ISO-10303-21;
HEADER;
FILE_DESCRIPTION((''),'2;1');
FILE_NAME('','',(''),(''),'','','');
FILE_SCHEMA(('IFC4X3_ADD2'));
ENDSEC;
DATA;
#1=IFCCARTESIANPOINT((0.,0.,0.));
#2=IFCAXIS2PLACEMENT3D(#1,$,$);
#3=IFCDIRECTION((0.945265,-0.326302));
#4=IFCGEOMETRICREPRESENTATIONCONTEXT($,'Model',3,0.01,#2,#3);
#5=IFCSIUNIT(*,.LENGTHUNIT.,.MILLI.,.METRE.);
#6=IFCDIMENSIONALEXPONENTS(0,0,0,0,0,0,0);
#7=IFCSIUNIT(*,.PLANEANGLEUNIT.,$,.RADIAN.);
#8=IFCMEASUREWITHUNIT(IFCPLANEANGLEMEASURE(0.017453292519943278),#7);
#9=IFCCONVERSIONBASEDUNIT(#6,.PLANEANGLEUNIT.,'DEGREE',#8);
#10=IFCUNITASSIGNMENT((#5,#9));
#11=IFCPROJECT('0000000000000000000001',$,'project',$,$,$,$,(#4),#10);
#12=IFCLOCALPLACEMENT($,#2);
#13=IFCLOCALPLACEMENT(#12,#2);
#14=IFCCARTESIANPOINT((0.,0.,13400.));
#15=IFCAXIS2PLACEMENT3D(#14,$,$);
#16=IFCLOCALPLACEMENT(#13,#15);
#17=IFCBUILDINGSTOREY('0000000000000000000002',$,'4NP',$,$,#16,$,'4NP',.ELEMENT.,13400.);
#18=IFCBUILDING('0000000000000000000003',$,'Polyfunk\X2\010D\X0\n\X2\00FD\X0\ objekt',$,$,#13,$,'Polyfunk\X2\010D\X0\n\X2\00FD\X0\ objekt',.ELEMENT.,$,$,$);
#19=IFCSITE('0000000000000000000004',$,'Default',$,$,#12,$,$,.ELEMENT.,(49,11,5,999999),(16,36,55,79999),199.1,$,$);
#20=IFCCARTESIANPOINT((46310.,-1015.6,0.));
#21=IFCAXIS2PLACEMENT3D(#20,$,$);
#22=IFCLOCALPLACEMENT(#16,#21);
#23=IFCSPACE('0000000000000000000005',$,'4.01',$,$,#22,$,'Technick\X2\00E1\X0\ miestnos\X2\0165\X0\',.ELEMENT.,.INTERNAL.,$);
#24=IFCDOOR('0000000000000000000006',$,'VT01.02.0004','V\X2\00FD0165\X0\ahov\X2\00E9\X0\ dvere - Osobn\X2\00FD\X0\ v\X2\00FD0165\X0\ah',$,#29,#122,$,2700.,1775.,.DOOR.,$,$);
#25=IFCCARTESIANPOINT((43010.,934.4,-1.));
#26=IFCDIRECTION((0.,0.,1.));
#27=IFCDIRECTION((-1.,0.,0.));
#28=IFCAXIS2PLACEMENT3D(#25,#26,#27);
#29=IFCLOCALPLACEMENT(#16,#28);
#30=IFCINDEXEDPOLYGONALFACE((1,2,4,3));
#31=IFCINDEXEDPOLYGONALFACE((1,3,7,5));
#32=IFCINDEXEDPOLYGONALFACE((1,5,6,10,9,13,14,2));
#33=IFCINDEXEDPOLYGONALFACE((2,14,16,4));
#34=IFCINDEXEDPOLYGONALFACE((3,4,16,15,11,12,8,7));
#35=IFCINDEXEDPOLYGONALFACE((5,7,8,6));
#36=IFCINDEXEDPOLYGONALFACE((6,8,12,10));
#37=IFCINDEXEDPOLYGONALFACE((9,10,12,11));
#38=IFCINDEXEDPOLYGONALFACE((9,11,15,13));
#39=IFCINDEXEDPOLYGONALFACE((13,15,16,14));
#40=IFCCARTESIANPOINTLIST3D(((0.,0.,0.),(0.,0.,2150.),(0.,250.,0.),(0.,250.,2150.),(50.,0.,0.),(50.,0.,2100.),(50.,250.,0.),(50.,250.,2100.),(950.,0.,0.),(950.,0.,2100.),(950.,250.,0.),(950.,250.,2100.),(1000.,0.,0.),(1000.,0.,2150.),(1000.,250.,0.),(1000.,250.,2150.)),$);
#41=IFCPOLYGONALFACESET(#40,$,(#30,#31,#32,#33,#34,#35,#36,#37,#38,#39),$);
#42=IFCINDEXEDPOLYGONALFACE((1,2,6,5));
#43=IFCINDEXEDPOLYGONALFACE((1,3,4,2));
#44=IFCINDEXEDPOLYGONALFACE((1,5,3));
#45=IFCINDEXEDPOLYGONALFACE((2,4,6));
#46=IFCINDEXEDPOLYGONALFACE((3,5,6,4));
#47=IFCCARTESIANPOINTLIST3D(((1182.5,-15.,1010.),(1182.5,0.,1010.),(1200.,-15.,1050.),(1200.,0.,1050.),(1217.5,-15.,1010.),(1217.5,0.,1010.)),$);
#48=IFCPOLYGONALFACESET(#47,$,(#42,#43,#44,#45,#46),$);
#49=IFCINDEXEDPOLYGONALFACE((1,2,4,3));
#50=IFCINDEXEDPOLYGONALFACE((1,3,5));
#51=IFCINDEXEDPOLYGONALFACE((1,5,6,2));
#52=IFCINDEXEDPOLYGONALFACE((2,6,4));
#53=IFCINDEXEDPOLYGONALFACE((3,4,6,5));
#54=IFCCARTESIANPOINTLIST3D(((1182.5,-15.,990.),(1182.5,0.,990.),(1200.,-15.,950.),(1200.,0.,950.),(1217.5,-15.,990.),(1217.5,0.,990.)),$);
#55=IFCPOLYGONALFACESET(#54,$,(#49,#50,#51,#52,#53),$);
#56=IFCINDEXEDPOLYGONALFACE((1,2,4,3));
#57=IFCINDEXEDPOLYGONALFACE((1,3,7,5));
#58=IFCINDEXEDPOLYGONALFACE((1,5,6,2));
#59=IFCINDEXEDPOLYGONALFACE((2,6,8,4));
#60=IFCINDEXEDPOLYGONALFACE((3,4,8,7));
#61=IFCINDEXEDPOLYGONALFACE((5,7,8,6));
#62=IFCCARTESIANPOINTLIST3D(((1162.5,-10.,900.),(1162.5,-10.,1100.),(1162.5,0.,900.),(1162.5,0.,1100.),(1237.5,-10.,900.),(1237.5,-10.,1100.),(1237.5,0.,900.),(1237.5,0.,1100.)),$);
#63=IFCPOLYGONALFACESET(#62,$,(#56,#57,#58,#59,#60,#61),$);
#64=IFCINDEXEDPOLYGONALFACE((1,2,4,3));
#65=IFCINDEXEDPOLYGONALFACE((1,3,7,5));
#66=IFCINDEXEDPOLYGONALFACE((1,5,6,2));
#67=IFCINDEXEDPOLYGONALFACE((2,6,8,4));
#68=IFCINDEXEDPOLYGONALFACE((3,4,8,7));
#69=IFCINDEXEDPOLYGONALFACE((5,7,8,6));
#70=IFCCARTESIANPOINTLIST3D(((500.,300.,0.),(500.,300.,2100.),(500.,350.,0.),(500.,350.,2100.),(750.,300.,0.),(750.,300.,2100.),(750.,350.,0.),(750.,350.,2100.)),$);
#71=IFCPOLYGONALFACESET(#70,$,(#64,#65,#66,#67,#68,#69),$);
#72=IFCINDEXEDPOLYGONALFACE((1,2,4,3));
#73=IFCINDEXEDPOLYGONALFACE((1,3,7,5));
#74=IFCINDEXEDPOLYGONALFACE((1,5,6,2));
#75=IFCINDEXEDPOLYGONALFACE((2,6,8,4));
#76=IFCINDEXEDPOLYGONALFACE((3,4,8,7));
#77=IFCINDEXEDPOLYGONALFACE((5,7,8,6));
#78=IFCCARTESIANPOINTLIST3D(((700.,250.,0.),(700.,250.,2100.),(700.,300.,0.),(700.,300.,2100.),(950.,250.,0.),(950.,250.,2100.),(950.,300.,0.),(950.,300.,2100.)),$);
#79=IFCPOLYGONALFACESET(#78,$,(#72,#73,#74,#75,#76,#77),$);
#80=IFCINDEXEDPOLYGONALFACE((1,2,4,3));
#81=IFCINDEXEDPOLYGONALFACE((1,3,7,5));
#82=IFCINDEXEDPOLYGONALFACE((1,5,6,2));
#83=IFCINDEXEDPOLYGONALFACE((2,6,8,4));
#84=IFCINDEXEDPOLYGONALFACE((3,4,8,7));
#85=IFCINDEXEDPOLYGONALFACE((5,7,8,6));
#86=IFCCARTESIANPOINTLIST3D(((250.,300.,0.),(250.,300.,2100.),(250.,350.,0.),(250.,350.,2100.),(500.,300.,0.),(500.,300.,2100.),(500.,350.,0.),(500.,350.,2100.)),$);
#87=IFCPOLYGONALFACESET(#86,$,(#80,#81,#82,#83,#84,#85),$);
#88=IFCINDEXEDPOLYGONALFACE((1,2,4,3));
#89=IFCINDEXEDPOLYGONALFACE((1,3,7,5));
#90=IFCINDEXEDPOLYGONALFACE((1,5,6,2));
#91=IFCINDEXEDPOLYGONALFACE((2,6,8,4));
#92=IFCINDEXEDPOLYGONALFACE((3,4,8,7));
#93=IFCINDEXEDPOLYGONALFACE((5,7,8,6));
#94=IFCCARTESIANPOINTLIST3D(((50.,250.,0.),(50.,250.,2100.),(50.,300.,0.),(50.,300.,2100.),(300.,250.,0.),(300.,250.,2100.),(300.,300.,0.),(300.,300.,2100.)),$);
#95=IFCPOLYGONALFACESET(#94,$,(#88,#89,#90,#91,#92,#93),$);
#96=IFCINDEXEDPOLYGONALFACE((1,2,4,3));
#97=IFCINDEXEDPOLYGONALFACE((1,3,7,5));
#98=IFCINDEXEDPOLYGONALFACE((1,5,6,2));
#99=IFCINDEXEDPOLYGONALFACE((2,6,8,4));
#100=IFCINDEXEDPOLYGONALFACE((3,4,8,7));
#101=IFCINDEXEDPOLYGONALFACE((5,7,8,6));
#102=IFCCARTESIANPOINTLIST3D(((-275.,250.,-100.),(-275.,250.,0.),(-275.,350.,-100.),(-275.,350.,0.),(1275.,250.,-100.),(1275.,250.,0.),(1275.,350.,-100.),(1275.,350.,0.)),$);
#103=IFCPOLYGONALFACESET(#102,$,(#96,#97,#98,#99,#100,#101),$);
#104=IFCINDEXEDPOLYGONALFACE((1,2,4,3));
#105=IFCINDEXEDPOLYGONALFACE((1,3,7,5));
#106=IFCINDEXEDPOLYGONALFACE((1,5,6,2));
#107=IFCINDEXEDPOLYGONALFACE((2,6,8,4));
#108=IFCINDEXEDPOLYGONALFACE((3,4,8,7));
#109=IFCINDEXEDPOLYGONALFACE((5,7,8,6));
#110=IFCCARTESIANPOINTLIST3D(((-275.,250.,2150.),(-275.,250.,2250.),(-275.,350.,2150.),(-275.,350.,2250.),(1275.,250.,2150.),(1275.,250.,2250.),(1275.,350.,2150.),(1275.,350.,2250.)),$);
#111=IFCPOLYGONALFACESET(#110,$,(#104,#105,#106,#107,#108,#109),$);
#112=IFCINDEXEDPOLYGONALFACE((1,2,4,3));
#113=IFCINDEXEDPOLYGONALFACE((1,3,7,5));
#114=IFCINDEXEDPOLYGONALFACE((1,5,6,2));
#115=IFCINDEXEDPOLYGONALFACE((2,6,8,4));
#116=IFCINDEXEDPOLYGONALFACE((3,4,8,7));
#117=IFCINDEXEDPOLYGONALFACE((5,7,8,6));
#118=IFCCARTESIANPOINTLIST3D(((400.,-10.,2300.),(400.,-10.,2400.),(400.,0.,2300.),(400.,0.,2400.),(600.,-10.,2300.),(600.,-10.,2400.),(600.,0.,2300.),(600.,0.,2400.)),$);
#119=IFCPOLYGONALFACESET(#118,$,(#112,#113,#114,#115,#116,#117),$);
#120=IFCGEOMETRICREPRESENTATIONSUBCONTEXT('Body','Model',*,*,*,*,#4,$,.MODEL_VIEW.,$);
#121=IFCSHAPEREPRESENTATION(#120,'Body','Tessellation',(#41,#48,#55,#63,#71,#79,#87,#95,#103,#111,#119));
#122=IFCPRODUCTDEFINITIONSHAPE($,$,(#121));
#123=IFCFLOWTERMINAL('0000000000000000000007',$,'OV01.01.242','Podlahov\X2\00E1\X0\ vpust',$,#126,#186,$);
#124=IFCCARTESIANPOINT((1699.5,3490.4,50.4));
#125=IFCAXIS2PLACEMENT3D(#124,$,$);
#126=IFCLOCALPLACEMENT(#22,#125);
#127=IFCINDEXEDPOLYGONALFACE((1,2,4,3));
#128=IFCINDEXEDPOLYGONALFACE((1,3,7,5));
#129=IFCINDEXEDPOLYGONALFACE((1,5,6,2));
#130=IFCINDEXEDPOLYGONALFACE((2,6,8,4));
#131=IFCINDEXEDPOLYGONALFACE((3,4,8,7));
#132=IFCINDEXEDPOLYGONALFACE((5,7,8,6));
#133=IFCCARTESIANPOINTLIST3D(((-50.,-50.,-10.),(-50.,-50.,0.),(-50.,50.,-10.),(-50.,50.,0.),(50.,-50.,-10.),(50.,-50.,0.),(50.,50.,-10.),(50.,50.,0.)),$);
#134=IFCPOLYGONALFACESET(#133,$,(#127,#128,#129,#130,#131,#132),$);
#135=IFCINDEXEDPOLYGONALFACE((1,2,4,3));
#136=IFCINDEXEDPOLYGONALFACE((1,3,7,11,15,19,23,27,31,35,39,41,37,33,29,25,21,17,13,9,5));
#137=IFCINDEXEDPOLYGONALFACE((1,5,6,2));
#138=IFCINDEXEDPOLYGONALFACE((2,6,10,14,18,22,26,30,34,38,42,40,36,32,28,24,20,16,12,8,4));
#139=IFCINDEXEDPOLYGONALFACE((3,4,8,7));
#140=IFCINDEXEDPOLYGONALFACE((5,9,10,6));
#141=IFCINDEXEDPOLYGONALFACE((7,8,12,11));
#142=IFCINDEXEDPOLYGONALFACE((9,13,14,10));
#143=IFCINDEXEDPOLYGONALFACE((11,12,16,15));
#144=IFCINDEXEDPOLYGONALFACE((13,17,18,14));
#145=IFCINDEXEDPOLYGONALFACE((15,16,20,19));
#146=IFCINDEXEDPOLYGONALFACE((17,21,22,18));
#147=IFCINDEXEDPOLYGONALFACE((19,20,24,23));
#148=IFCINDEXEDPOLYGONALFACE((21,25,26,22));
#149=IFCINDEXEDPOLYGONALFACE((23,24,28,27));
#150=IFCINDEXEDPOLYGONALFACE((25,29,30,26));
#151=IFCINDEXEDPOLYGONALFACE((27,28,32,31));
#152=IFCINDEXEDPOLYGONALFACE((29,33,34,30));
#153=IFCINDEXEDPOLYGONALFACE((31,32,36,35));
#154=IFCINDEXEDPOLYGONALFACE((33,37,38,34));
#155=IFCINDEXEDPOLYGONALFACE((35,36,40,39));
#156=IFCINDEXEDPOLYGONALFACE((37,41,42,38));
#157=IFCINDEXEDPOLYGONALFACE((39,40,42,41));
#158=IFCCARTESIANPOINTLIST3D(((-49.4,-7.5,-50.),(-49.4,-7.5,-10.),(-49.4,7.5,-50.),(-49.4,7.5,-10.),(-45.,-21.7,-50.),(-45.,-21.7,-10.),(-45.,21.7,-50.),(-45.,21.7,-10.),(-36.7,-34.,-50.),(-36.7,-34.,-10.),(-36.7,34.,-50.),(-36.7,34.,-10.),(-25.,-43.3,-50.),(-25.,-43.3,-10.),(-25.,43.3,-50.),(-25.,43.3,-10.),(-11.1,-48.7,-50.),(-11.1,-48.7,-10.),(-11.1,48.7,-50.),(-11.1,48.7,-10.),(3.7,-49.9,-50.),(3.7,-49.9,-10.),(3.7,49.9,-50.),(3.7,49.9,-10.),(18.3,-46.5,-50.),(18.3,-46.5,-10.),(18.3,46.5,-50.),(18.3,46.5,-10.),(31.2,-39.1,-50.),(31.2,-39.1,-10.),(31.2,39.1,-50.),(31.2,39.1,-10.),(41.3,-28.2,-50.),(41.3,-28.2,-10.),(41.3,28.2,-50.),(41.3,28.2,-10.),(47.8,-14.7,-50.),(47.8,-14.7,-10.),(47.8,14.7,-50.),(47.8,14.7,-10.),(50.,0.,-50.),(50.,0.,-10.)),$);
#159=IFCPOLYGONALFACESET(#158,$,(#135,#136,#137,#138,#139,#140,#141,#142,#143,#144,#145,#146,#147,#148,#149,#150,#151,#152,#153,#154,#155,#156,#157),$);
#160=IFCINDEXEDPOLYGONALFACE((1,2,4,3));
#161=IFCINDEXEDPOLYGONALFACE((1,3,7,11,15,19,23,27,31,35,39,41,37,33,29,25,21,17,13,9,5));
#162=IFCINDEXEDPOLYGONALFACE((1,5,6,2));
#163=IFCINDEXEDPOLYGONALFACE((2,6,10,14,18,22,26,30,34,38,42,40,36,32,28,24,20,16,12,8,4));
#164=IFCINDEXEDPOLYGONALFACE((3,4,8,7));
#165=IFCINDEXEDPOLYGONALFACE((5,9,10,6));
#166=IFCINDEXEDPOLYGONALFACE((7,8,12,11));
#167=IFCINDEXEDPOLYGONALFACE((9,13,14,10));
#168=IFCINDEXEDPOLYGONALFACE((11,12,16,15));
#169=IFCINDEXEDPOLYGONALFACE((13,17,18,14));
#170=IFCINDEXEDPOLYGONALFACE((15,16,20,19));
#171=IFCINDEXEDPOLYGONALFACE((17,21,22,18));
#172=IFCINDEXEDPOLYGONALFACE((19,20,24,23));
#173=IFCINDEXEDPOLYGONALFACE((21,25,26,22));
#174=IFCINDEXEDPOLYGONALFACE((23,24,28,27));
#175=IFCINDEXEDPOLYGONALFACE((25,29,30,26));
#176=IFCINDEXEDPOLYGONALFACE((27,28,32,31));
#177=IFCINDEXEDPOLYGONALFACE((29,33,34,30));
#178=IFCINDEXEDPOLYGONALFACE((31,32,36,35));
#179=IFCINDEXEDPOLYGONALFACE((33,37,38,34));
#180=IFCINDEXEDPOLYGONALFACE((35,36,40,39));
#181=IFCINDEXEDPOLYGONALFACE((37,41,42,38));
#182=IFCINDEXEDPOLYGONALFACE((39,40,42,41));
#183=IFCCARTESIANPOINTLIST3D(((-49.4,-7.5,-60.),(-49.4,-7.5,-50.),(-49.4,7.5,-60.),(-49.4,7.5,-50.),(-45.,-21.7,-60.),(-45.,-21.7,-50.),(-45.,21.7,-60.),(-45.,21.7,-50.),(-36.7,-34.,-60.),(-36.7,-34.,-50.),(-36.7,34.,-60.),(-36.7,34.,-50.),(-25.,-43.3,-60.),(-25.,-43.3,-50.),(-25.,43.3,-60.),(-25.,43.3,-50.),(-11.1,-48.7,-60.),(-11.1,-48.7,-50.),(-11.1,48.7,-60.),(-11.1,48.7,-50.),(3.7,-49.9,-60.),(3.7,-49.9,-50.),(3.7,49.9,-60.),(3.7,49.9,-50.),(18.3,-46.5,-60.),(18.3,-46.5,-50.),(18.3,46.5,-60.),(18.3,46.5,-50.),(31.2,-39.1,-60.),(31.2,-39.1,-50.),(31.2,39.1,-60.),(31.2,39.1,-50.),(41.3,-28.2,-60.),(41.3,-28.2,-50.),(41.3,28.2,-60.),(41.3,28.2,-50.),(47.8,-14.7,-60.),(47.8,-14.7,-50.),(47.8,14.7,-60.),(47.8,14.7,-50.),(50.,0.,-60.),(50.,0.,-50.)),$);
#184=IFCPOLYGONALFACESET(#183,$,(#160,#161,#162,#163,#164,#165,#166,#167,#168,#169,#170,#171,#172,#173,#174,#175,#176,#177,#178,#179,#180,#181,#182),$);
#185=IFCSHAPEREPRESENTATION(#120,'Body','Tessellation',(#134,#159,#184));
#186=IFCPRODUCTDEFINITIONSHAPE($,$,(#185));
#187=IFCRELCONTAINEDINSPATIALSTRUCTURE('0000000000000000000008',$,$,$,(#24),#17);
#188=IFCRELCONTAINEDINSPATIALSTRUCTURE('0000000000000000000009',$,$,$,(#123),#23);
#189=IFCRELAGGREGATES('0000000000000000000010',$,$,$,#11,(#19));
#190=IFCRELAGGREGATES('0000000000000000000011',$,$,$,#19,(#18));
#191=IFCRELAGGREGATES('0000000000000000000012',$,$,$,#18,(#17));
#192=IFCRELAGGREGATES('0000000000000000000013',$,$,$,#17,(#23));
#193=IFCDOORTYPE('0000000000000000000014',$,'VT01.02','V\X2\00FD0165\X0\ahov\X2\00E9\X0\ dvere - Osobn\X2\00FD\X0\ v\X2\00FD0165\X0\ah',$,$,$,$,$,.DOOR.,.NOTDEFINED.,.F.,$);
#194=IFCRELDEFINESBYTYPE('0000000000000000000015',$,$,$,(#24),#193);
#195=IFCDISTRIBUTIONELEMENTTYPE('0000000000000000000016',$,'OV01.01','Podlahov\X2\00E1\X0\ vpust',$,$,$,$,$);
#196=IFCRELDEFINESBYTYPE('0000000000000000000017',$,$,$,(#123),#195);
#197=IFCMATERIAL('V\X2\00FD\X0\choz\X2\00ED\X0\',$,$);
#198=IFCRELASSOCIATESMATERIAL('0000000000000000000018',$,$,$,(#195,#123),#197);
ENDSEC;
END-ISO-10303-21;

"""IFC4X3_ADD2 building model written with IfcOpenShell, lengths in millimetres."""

from ifc_helpers import new_model, entity, si_unit, converted_unit, direction, frame, frame_2d, origin, origin_2d_with_axis, place, context, subcontext, project, spatial, polyline, rectangle, circle, outline, extrude, source, transform, mapped, material, type_object, type_shapes, element, save


model = new_model("IFC4X3_ADD2")

# Units and contexts
model_context = context("Model", 3, precision=0.01, world=origin(), true_north=direction((0.945265, -0.326302)))
body_context = subcontext(model_context, "Body", "Model", "MODEL_VIEW")
ifc_project = project(units=[si_unit("LENGTHUNIT", "METRE", prefix="MILLI"), converted_unit("PLANEANGLEUNIT", "DEGREE", entity("IfcPlaneAngleMeasure", 0.017453292519943278), si_unit("PLANEANGLEUNIT", "RADIAN"), dimensions=[0, 0, 0, 0, 0, 0, 0])], contexts=[model_context])

# Site, building, storey
site_placement = place(None, origin())
site = spatial("IfcSite", under=ifc_project, at=site_placement, Name="Default", CompositionType="ELEMENT", RefLatitude=(49, 11, 5, 999999), RefLongitude=(16, 36, 55, 79999), RefElevation=199.1)
building_placement = place(site_placement, origin())
building = spatial("IfcBuilding", under=site, at=building_placement, Name="Polyfunkčný objekt", LongName="Polyfunkčný objekt", CompositionType="ELEMENT")
storey_placement = place(building_placement, frame((0.0, 0.0, 13400.0)))
storey = spatial("IfcBuildingStorey", under=building, at=storey_placement, Name="4NP", LongName="4NP", CompositionType="ELEMENT", Elevation=13400.0)

# Door
door_type_1 = type_object("IfcDoorType", Name="VT01.02", Description="Výťahové dvere - Osobný výťah", OperationType="NOTDEFINED", ParameterTakesPrecedence=False, PredefinedType="DOOR")
shared_shape_1 = source(origin(), body_context, "Body", "SweptSolid", [
    extrude(outline(polyline([(-1087.5, -500.0), (1062.5, -500.0), (1062.5, -450.0), (-1037.5, -450.0), (-1037.5, 450.0), (1062.5, 450.0), (1062.5, 500.0), (-1087.5, 500.0), (-1087.5, -500.0)])), frame((500.0, 0.0, 1062.5), z_axis=(0.0, 1.0, 0.0), x_axis=(0.0, 0.0, -1.0)), (0.0, 0.0, 1.0), 250.0),
    extrude(outline(polyline([(-24.4, -10.7), (19.2, -10.7), (5.2, 21.4), (-24.4, -10.7)])), frame((1200.0, -15.0, 1023.3), z_axis=(0.0, 1.0, 0.0), x_axis=(0.400819, 0.0, -0.916157)), (0.0, 0.0, 1.0), 15.0),
    extrude(outline(polyline([(-24.4, -10.7), (19.2, -10.7), (5.2, 21.4), (-24.4, -10.7)])), frame((1200.0, -15.0, 976.7), z_axis=(0.0, 1.0, 0.0), x_axis=(-0.400819, 0.0, 0.916157)), (0.0, 0.0, 1.0), 15.0),
    extrude(rectangle(XDim=10.0, YDim=75.0, at=frame_2d((0.0, 0.0), x_axis=(1.0, 0.0))), frame((1200.0, -5.0, 900.0), z_axis=(0.0, 0.0, 1.0), x_axis=(0.0, 1.0, 0.0)), (0.0, 0.0, 1.0), 200.0),
    extrude(rectangle(XDim=50.0, YDim=250.0, at=origin_2d_with_axis()), frame((625.0, 325.0, 0.0), z_axis=(0.0, 0.0, 1.0), x_axis=(0.0, -1.0, 0.0)), (0.0, 0.0, 1.0), 2100.0),
    extrude(rectangle(XDim=50.0, YDim=250.0, at=frame_2d((0.0, 0.0), x_axis=(1.0, 0.0))), frame((825.0, 275.0, 0.0), z_axis=(0.0, 0.0, 1.0), x_axis=(0.0, -1.0, 0.0)), (0.0, 0.0, 1.0), 2100.0),
    extrude(rectangle(XDim=250.0, YDim=50.0, at=frame_2d((0.0, 0.0), x_axis=(1.0, 0.0))), frame((375.0, 325.0, 0.0), z_axis=(0.0, 0.0, 1.0), x_axis=(-1.0, 0.0, 0.0)), (0.0, 0.0, 1.0), 2100.0),
    extrude(rectangle(XDim=250.0, YDim=50.0, at=frame_2d((0.0, 0.0), x_axis=(1.0, 0.0))), frame((175.0, 275.0, 0.0), z_axis=(0.0, 0.0, 1.0), x_axis=(-1.0, 0.0, 0.0)), (0.0, 0.0, 1.0), 2100.0),
    extrude(rectangle(XDim=1550.0, YDim=100.0, at=frame_2d((0.0, 0.0), x_axis=(1.0, 0.0))), frame((500.0, 300.0, -100.0), z_axis=(0.0, 0.0, 1.0), x_axis=(-1.0, 0.0, 0.0)), (0.0, 0.0, 1.0), 100.0),
    extrude(rectangle(XDim=1550.0, YDim=100.0, at=frame_2d((0.0, 0.0), x_axis=(1.0, 0.0))), frame((500.0, 300.0, 2150.0), z_axis=(0.0, 0.0, 1.0), x_axis=(-1.0, 0.0, 0.0)), (0.0, 0.0, 1.0), 100.0),
    extrude(rectangle(XDim=10.0, YDim=200.0, at=frame_2d((0.0, 0.0), x_axis=(1.0, 0.0))), frame((500.0, -5.0, 2300.0), z_axis=(0.0, 0.0, 1.0), x_axis=(0.0, 1.0, 0.0)), (0.0, 0.0, 1.0), 100.0),
])
type_shapes(door_type_1, [shared_shape_1])
door_1_placement = place(storey_placement, frame((43010.0, 934.4, -1.0), z_axis=(0.0, 0.0, 1.0), x_axis=(-1.0, 0.0, 0.0)))
element("IfcDoor", 1, at=door_1_placement, inside=storey, type_object=door_type_1, Name="VT01.02.0004", Description="Výťahové dvere - Osobný výťah", OverallHeight=2700.0, OverallWidth=1775.0, PredefinedType="DOOR", context=body_context, shape_type="MappedRepresentation", body=[
    mapped(shared_shape_1, transform((0.0, 0.0, 0.0), scale=1.0)),
])

# Shared definitions
space_placement = place(storey_placement, frame((46310.0, -1015.6, 0.0)))
space = spatial("IfcSpace", under=storey, at=space_placement, Name="4.01", LongName="Technická miestnosť", CompositionType="ELEMENT", PredefinedType="INTERNAL")

# Flow terminal
ifc_material_1 = material(Name="Výchozí")
distribution_element_type = type_object("IfcDistributionElementType", Name="OV01.01", Description="Podlahová vpust", material=ifc_material_1)
shared_shape_2 = source(origin(), body_context, "Body", "SweptSolid", [
    extrude(rectangle(XDim=100.0, YDim=100.0, at=frame_2d((0.0, 0.0), x_axis=(1.0, 0.0))), frame((0.0, 0.0, -10.0), z_axis=(0.0, 0.0, 1.0), x_axis=(-1.0, 0.0, 0.0)), (0.0, 0.0, 1.0), 10.0),
    extrude(circle(Radius=50.0, at=frame_2d((0.0, 0.0), x_axis=(1.0, 0.0))), frame((0.0, 0.0, -50.0)), (0.0, 0.0, 1.0), 40.0),
    extrude(circle(Radius=50.0, at=frame_2d((0.0, 0.0), x_axis=(1.0, 0.0))), frame((0.0, 0.0, -60.0)), (0.0, 0.0, 1.0), 10.0),
])
type_shapes(distribution_element_type, [shared_shape_2])
flow_terminal_placement = place(space_placement, frame((1699.5, 3490.4, 50.4)))
element("IfcFlowTerminal", 2, at=flow_terminal_placement, inside=space, type_object=distribution_element_type, material=ifc_material_1, Name="OV01.01.242", Description="Podlahová vpust", context=body_context, shape_type="MappedRepresentation", body=[
    mapped(shared_shape_2, transform((0.0, 0.0, 0.0), scale=1.0)),
])

save(model, "model.ifc")
